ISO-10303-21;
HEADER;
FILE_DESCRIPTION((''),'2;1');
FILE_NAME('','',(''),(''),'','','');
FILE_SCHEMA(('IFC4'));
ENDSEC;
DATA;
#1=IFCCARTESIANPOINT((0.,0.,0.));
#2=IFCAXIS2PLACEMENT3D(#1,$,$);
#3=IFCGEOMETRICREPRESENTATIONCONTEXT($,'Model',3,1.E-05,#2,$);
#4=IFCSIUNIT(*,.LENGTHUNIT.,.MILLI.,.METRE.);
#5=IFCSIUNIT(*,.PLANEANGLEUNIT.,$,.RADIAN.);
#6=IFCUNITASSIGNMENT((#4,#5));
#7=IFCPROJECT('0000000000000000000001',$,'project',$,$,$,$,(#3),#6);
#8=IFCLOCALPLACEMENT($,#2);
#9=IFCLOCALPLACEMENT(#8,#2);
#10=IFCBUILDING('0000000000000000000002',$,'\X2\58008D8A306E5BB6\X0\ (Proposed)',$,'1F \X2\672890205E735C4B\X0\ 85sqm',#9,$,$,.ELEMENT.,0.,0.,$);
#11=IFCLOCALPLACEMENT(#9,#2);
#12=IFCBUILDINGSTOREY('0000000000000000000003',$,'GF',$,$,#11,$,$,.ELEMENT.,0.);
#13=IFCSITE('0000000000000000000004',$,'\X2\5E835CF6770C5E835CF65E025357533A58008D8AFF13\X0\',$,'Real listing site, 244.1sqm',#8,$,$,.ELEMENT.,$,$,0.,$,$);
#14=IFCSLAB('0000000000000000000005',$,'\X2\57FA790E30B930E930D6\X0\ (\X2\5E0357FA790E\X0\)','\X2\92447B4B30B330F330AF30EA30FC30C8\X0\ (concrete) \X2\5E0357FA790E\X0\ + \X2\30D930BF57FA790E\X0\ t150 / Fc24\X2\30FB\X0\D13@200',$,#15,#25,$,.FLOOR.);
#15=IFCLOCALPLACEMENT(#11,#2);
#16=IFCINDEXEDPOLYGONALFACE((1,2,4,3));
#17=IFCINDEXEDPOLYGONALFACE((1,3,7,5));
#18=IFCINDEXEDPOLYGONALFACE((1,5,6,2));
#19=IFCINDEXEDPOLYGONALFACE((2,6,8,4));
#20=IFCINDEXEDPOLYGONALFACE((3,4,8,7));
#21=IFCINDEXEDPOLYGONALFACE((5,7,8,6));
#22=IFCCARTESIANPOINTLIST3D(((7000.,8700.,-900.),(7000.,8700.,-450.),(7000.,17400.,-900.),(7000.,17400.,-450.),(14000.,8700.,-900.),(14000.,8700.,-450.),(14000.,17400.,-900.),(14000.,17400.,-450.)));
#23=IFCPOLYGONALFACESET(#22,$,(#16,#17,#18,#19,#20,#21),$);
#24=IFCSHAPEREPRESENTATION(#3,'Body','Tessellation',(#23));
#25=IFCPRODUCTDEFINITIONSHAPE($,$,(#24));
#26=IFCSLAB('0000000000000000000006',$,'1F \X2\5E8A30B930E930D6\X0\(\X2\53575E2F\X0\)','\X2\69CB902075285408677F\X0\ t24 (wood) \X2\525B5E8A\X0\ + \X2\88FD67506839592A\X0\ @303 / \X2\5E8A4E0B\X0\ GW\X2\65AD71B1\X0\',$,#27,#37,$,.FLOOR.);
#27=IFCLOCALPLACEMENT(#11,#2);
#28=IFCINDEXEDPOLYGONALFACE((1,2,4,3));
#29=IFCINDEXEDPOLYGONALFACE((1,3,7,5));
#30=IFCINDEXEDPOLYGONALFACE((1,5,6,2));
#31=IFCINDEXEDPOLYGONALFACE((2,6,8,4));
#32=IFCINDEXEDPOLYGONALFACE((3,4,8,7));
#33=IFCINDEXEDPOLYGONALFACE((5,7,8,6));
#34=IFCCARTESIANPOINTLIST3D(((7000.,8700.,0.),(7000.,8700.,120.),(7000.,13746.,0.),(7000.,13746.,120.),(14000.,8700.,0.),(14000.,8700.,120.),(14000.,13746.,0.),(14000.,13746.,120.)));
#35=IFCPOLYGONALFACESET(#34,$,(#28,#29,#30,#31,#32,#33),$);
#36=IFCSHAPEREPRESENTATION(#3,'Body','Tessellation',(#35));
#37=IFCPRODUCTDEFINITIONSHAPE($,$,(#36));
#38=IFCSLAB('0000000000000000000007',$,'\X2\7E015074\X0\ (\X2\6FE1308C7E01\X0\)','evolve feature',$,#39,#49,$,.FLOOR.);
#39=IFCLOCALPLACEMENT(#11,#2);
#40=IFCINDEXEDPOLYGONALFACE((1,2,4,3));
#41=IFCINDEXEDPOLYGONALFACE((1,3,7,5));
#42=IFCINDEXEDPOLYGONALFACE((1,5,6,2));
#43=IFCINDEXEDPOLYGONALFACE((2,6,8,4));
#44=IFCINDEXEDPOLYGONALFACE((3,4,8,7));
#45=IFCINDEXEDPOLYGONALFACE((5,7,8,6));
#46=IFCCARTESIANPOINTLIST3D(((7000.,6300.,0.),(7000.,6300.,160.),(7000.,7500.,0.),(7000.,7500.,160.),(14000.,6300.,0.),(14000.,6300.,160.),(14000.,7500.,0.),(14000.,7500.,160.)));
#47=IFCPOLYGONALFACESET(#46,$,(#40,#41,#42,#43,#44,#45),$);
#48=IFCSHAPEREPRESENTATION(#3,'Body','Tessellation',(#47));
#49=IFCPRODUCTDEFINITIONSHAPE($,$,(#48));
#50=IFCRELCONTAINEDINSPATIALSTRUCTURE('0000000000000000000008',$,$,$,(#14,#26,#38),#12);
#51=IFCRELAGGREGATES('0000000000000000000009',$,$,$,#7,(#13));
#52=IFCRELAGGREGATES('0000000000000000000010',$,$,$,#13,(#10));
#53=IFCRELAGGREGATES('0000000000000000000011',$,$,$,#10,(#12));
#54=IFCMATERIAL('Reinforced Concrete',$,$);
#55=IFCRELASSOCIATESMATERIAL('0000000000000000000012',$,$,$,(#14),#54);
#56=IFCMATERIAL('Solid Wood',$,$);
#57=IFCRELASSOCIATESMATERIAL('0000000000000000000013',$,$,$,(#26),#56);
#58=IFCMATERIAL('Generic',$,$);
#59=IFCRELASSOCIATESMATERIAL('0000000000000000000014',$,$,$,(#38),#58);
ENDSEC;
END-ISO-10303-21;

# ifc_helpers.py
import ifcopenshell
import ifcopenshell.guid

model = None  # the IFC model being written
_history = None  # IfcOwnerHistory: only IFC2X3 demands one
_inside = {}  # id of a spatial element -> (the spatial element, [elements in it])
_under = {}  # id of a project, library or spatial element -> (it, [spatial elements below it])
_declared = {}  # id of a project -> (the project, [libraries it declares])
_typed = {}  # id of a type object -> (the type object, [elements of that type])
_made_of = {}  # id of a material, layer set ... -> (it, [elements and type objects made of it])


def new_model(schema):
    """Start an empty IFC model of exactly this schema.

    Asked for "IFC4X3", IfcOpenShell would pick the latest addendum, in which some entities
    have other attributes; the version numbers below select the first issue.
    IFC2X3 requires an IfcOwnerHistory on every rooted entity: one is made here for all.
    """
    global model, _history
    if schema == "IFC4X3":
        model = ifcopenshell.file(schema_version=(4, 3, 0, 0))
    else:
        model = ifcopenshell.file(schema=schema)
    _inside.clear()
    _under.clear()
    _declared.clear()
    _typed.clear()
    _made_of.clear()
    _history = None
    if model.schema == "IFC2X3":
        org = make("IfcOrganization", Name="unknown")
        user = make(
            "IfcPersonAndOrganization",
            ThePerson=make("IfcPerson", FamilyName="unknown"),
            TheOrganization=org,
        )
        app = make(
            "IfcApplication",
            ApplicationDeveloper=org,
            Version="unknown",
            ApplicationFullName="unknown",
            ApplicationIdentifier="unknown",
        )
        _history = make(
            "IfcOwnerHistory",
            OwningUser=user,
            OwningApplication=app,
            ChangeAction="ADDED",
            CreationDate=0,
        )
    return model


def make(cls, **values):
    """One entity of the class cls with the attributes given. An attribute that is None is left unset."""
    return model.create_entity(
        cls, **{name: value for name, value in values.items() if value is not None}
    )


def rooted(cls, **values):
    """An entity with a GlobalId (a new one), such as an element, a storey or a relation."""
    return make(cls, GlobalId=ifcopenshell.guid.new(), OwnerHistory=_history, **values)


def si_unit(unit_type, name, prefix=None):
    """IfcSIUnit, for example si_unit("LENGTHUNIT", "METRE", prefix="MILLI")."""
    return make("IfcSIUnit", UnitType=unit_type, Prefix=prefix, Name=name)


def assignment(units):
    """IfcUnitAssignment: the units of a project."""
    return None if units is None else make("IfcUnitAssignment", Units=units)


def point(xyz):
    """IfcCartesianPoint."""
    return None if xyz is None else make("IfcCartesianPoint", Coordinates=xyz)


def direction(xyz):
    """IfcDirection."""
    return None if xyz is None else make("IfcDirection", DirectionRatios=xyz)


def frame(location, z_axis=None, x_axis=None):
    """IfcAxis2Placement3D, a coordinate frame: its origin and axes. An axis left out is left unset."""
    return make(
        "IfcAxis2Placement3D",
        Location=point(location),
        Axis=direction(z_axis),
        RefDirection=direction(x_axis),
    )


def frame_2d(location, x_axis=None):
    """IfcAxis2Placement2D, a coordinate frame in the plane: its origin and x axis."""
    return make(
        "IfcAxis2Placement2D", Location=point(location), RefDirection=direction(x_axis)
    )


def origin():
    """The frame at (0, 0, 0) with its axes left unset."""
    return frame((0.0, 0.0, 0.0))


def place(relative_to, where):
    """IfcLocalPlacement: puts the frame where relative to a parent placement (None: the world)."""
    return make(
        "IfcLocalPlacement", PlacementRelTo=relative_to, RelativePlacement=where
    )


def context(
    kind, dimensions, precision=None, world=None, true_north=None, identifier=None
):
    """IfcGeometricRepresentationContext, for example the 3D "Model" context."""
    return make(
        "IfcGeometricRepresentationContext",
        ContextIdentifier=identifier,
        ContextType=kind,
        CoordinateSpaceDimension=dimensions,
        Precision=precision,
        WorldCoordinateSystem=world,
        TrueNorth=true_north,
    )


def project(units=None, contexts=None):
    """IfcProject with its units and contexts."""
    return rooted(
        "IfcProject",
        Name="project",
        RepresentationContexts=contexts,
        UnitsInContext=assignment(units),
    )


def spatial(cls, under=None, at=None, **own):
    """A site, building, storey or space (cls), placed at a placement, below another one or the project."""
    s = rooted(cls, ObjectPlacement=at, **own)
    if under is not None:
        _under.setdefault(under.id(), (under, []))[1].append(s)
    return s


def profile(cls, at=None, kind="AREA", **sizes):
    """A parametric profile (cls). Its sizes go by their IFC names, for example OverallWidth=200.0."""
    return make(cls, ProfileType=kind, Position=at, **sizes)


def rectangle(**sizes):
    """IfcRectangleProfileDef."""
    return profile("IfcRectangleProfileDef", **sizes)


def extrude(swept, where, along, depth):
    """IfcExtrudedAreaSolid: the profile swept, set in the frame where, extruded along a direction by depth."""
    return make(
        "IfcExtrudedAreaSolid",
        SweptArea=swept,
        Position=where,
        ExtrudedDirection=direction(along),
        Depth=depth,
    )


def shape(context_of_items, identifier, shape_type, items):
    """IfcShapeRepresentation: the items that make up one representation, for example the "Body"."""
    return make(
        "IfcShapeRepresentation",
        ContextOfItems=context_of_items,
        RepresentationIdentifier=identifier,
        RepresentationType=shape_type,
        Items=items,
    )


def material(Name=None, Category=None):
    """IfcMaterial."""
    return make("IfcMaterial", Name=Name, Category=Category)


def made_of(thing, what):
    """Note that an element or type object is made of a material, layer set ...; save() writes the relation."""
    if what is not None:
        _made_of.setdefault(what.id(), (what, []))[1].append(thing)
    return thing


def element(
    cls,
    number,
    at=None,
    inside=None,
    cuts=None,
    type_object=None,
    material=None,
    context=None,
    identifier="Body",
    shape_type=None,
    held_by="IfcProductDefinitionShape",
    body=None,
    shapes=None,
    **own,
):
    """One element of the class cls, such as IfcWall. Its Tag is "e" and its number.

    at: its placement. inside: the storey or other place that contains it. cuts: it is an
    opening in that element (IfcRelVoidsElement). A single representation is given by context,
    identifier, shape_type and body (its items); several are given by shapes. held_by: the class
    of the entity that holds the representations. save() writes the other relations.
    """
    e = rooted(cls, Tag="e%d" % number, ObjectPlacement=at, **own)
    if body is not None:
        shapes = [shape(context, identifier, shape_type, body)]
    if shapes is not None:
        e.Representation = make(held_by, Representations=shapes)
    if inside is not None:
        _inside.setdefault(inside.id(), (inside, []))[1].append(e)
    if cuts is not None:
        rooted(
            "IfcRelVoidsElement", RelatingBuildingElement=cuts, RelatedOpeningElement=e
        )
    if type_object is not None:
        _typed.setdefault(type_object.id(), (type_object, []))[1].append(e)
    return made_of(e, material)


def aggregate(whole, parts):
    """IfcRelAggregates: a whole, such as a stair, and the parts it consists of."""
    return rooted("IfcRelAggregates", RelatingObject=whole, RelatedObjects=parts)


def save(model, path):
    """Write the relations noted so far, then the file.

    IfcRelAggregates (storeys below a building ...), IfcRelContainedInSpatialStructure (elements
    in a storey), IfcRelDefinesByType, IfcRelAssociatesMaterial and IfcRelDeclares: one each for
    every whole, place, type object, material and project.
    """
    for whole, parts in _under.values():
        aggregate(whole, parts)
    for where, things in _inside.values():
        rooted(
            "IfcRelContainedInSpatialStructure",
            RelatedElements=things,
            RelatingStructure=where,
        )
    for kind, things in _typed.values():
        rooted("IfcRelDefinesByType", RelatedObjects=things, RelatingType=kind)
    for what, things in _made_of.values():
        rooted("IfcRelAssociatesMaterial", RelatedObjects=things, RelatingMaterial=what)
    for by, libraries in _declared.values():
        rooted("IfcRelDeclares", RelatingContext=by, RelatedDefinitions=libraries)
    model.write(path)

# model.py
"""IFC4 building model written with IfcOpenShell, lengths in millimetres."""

from ifc_helpers import new_model, si_unit, frame, frame_2d, origin, place, context, project, spatial, rectangle, extrude, material, element, save


model = new_model("IFC4")

# Units and contexts
model_context = context("Model", 3, precision=1e-05, world=origin())
ifc_project = project(units=[si_unit("LENGTHUNIT", "METRE", prefix="MILLI"), si_unit("PLANEANGLEUNIT", "RADIAN")], contexts=[model_context])

# Site, building, storey
site_placement = place(None, origin())
site = spatial("IfcSite", under=ifc_project, at=site_placement, Name="広島県広島市南区堀越３", ObjectType="Real listing site, 244.1sqm", CompositionType="ELEMENT", RefElevation=0.0)
building_placement = place(site_placement, origin())
building = spatial("IfcBuilding", under=site, at=building_placement, Name="堀越の家 (Proposed)", ObjectType="1F 木造平屋 85sqm", CompositionType="ELEMENT", ElevationOfRefHeight=0.0, ElevationOfTerrain=0.0)
storey_placement = place(building_placement, origin())
storey = spatial("IfcBuildingStorey", under=building, at=storey_placement, Name="GF", CompositionType="ELEMENT", Elevation=0.0)

# Slabs
ifc_material_1 = material(Name="Reinforced Concrete")
slab_1_placement = place(storey_placement, frame((3500.0, 4350.0, -450.0)))
element("IfcSlab", 1, at=slab_1_placement, inside=storey, material=ifc_material_1, Name="基礎スラブ (布基礎)", Description="鉄筋コンクリート (concrete) 布基礎 + ベタ基礎 t150 / Fc24・D13@200", PredefinedType="FLOOR", context=model_context, shape_type="SweptSolid", body=[
    extrude(rectangle(XDim=7000.0, YDim=8700.0, at=frame_2d((3500.0, 4350.0))), frame((3500.0, 4350.0, -450.0)), (0.0, 0.0, 1.0), 450.0),
])
ifc_material_2 = material(Name="Solid Wood")
slab_2_placement = place(storey_placement, frame((3500.0, 4350.0, 0.0)))
element("IfcSlab", 2, at=slab_2_placement, inside=storey, material=ifc_material_2, Name="1F 床スラブ(南帯)", Description="構造用合板 t24 (wood) 剛床 + 製材根太 @303 / 床下 GW断熱", PredefinedType="FLOOR", context=model_context, shape_type="SweptSolid", body=[
    extrude(rectangle(XDim=7000.0, YDim=5046.0, at=frame_2d((3500.0, 2523.0))), frame((3500.0, 4350.0, 0.0)), (0.0, 0.0, 1.0), 120.0),
])
ifc_material_3 = material(Name="Generic")
slab_3_placement = place(storey_placement, frame((3500.0, 3150.0, 0.0)))
element("IfcSlab", 3, at=slab_3_placement, inside=storey, material=ifc_material_3, Name="縁側 (濡れ縁)", Description="evolve feature", PredefinedType="FLOOR", context=model_context, shape_type="SweptSolid", body=[
    extrude(rectangle(XDim=7000.0, YDim=1200.0, at=frame_2d((3500.0, 600.0))), frame((3500.0, 3150.0, 0.0)), (0.0, 0.0, 1.0), 160.0),
])

save(model, "model.ifc")
